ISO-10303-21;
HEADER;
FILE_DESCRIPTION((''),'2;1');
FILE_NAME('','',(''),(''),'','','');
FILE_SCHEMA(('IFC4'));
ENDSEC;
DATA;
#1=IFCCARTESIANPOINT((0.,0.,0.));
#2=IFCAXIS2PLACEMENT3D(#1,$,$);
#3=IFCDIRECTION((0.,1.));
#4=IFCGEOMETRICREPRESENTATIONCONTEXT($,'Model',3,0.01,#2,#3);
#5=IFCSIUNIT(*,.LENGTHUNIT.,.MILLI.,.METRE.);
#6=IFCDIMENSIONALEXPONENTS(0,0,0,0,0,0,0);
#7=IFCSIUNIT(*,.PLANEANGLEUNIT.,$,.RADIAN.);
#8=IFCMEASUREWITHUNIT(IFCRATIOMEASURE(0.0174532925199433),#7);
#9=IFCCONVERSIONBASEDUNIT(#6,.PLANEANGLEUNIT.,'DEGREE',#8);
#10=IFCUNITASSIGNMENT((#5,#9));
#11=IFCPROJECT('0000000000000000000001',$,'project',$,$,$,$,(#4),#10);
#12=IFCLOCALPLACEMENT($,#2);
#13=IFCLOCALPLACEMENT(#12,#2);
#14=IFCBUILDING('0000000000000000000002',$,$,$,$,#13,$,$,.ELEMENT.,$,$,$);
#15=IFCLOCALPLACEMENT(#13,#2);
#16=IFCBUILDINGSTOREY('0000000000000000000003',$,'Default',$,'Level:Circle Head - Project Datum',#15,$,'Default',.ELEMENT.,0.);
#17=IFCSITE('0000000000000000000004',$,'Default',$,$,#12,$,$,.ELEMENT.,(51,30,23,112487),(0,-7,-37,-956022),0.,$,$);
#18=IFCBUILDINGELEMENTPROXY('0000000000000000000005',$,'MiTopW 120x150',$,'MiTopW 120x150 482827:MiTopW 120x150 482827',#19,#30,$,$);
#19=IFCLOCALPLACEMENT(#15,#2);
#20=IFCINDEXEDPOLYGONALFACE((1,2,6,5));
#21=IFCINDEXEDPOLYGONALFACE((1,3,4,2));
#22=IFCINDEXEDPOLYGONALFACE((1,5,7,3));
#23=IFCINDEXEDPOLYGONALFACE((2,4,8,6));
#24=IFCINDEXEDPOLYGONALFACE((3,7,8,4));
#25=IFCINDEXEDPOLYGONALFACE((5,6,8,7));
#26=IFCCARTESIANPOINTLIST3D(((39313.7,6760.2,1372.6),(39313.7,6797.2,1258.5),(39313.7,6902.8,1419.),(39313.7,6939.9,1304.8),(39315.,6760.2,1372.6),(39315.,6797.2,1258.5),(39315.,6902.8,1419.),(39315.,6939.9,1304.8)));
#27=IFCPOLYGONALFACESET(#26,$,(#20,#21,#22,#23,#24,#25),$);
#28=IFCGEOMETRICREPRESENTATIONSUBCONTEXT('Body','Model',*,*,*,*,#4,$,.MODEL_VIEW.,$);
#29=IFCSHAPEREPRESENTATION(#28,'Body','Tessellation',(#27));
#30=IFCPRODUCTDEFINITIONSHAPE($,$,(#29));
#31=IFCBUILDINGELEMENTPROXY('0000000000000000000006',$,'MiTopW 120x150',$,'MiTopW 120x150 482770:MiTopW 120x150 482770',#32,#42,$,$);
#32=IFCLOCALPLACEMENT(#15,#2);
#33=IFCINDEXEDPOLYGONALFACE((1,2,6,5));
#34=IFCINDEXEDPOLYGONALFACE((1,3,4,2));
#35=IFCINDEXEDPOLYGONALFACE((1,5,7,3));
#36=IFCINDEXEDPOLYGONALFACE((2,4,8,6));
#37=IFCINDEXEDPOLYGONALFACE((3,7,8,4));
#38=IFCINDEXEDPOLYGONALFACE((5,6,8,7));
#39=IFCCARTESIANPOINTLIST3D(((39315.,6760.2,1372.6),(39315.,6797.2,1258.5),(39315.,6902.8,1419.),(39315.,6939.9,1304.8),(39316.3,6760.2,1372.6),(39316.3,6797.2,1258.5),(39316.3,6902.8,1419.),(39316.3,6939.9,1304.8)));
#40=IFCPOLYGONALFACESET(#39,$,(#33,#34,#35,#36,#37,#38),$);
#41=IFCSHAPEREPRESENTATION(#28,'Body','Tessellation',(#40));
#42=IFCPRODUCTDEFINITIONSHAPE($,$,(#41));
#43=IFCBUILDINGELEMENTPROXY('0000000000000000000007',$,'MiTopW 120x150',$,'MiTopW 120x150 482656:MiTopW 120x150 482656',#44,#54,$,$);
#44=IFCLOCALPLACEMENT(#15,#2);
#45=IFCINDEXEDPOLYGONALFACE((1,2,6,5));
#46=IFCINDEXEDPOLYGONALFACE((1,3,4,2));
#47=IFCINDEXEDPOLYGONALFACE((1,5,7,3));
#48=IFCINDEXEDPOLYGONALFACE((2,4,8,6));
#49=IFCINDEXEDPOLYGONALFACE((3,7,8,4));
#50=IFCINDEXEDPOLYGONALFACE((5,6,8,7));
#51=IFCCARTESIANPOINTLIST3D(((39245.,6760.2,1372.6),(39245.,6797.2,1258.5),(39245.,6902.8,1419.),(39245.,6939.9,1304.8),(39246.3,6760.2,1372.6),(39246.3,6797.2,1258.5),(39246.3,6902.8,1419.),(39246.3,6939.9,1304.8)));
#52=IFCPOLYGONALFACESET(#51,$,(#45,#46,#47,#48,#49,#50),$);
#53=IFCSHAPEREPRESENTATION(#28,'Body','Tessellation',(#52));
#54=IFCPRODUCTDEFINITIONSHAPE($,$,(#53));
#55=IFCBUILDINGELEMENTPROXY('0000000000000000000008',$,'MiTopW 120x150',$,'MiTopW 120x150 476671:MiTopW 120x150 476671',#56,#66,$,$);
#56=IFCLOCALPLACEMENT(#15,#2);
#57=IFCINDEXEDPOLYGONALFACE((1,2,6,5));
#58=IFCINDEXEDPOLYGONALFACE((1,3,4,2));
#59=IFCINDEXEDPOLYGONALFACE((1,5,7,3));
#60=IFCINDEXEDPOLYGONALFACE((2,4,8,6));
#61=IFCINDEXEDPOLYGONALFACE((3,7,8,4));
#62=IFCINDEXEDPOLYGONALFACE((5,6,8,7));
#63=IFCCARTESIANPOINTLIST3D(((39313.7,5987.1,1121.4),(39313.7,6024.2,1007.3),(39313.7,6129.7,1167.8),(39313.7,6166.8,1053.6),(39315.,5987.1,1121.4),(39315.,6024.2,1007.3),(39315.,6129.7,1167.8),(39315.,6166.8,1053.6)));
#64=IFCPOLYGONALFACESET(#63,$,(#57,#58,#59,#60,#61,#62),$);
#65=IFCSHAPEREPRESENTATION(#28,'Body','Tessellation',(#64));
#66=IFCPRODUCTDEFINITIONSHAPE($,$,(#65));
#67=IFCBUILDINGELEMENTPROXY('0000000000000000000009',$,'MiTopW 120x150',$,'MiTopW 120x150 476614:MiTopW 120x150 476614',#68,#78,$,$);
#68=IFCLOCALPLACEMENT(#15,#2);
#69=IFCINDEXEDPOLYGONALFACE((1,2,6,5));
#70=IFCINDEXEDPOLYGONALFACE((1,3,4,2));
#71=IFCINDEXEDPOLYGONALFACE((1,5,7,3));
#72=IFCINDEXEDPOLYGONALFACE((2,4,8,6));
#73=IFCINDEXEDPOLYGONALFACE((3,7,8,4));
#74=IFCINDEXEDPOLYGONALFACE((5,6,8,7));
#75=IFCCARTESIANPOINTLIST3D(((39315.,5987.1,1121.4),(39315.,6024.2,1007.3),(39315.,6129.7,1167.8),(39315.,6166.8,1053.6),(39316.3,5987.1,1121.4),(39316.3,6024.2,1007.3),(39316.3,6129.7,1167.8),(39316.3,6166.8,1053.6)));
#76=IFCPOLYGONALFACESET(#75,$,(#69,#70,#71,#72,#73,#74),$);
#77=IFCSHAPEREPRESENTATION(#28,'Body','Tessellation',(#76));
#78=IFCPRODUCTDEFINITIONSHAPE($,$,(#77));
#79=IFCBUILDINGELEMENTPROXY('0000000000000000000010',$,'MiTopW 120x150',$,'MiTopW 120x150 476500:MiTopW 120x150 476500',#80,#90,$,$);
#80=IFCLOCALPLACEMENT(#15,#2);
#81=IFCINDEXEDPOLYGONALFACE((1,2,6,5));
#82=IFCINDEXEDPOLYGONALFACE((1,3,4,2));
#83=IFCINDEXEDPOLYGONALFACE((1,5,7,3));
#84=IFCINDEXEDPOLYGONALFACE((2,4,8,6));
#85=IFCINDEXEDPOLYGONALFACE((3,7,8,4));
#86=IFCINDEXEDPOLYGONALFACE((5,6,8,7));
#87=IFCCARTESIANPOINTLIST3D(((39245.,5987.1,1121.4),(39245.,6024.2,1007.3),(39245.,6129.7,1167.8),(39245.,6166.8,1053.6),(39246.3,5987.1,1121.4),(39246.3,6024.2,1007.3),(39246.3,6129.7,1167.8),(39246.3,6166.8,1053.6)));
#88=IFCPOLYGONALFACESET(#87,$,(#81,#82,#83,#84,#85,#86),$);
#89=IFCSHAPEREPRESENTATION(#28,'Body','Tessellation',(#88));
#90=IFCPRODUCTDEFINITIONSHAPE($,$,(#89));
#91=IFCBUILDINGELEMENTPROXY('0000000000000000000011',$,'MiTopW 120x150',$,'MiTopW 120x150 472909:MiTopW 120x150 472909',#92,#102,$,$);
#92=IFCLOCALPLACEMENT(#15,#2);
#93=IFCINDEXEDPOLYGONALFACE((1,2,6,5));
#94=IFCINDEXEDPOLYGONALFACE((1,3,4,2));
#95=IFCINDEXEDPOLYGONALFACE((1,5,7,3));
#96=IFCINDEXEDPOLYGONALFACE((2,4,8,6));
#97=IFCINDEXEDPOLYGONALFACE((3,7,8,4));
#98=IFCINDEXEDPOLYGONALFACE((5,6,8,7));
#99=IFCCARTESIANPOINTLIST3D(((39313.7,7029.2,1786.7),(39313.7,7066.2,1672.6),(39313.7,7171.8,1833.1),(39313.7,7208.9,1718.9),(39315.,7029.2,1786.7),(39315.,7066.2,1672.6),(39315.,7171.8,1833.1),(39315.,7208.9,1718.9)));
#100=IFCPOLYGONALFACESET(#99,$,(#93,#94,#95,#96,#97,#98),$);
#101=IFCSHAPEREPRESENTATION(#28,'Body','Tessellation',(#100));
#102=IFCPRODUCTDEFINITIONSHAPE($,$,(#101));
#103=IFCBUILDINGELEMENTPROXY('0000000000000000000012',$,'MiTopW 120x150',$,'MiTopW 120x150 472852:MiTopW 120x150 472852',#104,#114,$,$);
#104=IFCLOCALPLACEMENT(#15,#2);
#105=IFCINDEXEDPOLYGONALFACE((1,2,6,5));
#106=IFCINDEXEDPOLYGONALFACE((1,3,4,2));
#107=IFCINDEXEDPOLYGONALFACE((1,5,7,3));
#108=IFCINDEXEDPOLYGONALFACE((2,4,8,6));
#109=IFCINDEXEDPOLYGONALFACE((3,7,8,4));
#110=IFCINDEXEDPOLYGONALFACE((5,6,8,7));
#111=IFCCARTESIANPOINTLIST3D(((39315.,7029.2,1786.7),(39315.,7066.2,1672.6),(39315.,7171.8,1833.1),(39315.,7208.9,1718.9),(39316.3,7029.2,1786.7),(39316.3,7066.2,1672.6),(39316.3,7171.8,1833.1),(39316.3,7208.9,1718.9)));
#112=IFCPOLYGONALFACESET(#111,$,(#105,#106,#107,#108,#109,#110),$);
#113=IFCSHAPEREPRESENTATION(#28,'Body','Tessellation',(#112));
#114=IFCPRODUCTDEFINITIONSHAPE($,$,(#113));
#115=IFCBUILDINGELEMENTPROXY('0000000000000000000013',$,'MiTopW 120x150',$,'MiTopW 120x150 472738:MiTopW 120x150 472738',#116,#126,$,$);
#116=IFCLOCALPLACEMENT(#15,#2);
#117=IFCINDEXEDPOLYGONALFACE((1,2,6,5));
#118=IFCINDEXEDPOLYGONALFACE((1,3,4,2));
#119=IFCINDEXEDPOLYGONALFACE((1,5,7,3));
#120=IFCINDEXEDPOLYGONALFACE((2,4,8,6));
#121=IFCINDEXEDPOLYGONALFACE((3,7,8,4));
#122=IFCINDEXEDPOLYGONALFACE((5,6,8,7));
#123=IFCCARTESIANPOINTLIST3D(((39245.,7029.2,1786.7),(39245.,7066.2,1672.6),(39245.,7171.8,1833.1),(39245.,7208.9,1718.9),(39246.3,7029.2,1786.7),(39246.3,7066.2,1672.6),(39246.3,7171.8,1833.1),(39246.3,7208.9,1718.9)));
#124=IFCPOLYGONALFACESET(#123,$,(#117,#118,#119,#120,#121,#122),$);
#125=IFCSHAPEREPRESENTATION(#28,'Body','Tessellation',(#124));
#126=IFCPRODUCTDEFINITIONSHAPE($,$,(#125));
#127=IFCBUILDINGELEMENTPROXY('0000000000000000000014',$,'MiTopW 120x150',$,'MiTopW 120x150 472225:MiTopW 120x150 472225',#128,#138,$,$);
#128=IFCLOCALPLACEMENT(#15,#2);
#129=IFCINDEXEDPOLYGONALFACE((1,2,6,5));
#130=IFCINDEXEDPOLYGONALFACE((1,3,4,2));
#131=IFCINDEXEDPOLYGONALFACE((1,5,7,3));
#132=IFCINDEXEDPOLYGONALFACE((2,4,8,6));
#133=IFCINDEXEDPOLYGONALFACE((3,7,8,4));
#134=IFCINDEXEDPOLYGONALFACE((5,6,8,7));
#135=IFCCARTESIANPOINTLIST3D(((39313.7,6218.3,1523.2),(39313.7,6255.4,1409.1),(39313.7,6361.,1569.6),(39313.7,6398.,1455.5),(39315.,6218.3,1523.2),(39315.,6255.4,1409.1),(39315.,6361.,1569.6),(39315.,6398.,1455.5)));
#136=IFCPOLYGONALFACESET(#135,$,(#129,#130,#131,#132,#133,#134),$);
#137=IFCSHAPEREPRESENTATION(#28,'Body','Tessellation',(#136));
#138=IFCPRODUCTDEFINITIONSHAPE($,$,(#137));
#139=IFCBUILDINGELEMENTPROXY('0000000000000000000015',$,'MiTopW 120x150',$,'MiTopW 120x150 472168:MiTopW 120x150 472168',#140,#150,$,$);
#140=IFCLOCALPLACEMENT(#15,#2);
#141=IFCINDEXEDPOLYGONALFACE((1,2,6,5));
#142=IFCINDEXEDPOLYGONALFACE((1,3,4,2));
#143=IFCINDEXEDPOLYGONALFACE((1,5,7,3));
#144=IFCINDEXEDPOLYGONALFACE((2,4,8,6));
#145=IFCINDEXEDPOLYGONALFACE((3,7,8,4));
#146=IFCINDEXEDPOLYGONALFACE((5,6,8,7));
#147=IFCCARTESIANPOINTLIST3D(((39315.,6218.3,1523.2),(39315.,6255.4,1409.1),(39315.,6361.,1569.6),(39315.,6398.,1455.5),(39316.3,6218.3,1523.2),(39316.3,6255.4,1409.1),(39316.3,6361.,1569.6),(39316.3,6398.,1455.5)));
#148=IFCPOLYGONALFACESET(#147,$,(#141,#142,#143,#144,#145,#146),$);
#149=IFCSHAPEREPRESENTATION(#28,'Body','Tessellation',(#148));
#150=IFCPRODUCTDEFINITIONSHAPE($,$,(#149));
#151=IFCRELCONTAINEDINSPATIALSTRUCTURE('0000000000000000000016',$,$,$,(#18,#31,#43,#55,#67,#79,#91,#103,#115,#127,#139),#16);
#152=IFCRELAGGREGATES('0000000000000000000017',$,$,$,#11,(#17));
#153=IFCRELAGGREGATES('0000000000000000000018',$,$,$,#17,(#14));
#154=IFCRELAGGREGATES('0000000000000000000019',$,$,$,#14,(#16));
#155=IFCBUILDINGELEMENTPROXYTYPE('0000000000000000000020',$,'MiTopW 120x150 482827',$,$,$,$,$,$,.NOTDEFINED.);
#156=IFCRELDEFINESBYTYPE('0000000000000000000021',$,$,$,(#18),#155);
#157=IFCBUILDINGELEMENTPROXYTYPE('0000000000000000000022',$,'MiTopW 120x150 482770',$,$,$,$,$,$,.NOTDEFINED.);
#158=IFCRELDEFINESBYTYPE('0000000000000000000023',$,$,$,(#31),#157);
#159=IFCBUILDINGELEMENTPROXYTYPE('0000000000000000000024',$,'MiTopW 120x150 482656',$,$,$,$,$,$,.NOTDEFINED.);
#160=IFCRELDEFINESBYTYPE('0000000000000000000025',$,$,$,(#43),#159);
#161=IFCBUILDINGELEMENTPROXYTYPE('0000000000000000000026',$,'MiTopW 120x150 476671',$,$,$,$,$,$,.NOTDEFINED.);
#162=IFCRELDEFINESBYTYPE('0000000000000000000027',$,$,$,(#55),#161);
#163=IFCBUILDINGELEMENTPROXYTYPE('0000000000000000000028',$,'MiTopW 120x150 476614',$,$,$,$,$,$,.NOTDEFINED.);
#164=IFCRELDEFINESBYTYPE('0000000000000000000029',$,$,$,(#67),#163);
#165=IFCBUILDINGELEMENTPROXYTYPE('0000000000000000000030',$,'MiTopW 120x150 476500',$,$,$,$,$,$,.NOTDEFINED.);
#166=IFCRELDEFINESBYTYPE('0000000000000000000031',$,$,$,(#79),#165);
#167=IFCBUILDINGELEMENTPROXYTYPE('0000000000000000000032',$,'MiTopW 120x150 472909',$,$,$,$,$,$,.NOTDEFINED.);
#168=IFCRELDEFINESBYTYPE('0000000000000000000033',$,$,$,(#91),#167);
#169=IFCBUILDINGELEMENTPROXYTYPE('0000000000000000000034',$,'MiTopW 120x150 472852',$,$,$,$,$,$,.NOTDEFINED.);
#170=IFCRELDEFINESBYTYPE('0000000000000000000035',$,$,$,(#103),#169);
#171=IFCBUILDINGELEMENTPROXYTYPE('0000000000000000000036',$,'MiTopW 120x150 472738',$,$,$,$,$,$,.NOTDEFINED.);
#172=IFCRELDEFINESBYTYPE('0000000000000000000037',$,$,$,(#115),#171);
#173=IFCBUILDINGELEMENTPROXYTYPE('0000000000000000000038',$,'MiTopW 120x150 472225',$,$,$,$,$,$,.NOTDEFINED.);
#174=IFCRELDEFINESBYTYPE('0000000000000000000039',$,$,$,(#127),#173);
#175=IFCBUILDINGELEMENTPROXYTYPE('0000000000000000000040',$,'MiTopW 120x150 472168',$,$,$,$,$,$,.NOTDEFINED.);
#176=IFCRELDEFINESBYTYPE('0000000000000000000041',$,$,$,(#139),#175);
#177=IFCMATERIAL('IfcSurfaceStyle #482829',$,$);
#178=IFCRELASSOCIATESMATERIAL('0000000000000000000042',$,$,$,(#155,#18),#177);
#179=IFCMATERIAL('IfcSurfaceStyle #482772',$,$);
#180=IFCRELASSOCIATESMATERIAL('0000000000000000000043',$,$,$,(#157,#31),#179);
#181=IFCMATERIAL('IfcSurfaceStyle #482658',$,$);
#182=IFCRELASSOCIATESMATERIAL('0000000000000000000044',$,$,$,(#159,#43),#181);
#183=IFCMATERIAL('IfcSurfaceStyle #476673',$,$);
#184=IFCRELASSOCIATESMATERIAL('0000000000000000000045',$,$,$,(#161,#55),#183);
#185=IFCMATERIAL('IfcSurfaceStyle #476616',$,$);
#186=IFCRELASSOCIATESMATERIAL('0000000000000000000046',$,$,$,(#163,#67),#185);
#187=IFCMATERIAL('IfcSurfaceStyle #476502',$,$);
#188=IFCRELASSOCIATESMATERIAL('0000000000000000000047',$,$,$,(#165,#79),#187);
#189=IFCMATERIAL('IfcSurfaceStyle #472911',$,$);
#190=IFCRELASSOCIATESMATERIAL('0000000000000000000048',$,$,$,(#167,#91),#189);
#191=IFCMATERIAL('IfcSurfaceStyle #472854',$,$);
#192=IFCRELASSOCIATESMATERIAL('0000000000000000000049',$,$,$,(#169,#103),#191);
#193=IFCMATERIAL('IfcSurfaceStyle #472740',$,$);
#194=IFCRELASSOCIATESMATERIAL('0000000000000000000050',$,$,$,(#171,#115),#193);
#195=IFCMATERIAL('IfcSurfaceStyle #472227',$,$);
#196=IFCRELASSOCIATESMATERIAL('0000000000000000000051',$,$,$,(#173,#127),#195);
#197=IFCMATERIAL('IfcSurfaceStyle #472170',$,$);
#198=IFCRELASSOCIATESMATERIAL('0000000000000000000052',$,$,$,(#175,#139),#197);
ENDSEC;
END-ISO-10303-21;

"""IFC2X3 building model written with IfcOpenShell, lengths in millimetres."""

from ifc_helpers import new_model, entity, si_unit, converted_unit, direction, frame, origin, place, context, subcontext, project, spatial, polyline, outline, extrude, source, transform, mapped, material, type_object, type_shapes, element, save


model = new_model("IFC2X3")

# Units and contexts
model_context = context("Model", 3, precision=0.01, world=origin(), true_north=direction((0.0, 1.0)))
body_context = subcontext(model_context, "Body", "Model", "MODEL_VIEW")
ifc_project = project(units=[si_unit("LENGTHUNIT", "METRE", prefix="MILLI"), converted_unit("PLANEANGLEUNIT", "DEGREE", entity("IfcRatioMeasure", 0.0174532925199433), si_unit("PLANEANGLEUNIT", "RADIAN"), dimensions=[0, 0, 0, 0, 0, 0, 0])], contexts=[model_context])

# Site, building, storey
site_placement = place(None, origin())
site = spatial("IfcSite", under=ifc_project, at=site_placement, Name="Default", CompositionType="ELEMENT", RefLatitude=(51, 30, 23, 112487), RefLongitude=(0, -7, -37, -956022), RefElevation=0.0)
building_placement = place(site_placement, origin())
building = spatial("IfcBuilding", under=site, at=building_placement, CompositionType="ELEMENT")
storey_placement = place(building_placement, origin())
storey = spatial("IfcBuildingStorey", under=building, at=storey_placement, Name="Default", ObjectType="Level:Circle Head - Project Datum", LongName="Default", CompositionType="ELEMENT", Elevation=0.0)

# Building element proxies
ifc_material_1 = material(Name="IfcSurfaceStyle #482829")
building_element_proxy_type_1 = type_object("IfcBuildingElementProxyType", Name="MiTopW 120x150 482827", PredefinedType="NOTDEFINED", material=ifc_material_1)
shared_shape_1 = source(origin(), body_context, "Body", "SweptSolid", [
    extrude(outline(polyline([(-75.0, -60.0), (75.0, -60.0), (75.0, 60.0), (-75.0, 60.0), (-75.0, -60.0)])), frame((75.0, 60.0, 0.0), z_axis=(0.0, 0.0, 1.0), x_axis=(-1.0, 0.0, 0.0)), (0.0, 0.0, 1.0), 1.3),
])
type_shapes(building_element_proxy_type_1, [shared_shape_1])
proxy_1_placement = place(building_placement, frame((39315.0, 6760.2, 1372.6), z_axis=(-1.0, 0.0, 0.0), x_axis=(0.0, 0.951057, 0.309017)))
element("IfcBuildingElementProxy", 1, at=proxy_1_placement, inside=storey, type_object=building_element_proxy_type_1, material=ifc_material_1, Name="MiTopW 120x150", ObjectType="MiTopW 120x150 482827:MiTopW 120x150 482827", context=body_context, shape_type="MappedRepresentation", body=[
    mapped(shared_shape_1, transform((0.0, 0.0, 0.0), scale=1.0)),
])
ifc_material_2 = material(Name="IfcSurfaceStyle #482772")
building_element_proxy_type_2 = type_object("IfcBuildingElementProxyType", Name="MiTopW 120x150 482770", PredefinedType="NOTDEFINED", material=ifc_material_2)
shared_shape_2 = source(origin(), body_context, "Body", "SweptSolid", [
    extrude(outline(polyline([(-75.0, -60.0), (75.0, -60.0), (75.0, 60.0), (-75.0, 60.0), (-75.0, -60.0)])), frame((75.0, 60.0, 0.0), z_axis=(0.0, 0.0, 1.0), x_axis=(-1.0, 0.0, 0.0)), (0.0, 0.0, 1.0), 1.3),
])
type_shapes(building_element_proxy_type_2, [shared_shape_2])
proxy_2_placement = place(building_placement, frame((39316.3, 6760.2, 1372.6), z_axis=(-1.0, 0.0, 0.0), x_axis=(0.0, 0.951057, 0.309017)))
element("IfcBuildingElementProxy", 2, at=proxy_2_placement, inside=storey, type_object=building_element_proxy_type_2, material=ifc_material_2, Name="MiTopW 120x150", ObjectType="MiTopW 120x150 482770:MiTopW 120x150 482770", context=body_context, shape_type="MappedRepresentation", body=[
    mapped(shared_shape_2, transform((0.0, 0.0, 0.0), scale=1.0)),
])
ifc_material_3 = material(Name="IfcSurfaceStyle #482658")
building_element_proxy_type_3 = type_object("IfcBuildingElementProxyType", Name="MiTopW 120x150 482656", PredefinedType="NOTDEFINED", material=ifc_material_3)
shared_shape_3 = source(origin(), body_context, "Body", "SweptSolid", [
    extrude(outline(polyline([(-75.0, -60.0), (75.0, -60.0), (75.0, 60.0), (-75.0, 60.0), (-75.0, -60.0)])), frame((75.0, 60.0, 0.0), z_axis=(0.0, 0.0, 1.0), x_axis=(-1.0, 0.0, 0.0)), (0.0, 0.0, 1.0), 1.3),
])
type_shapes(building_element_proxy_type_3, [shared_shape_3])
proxy_3_placement = place(building_placement, frame((39246.3, 6760.2, 1372.6), z_axis=(-1.0, 0.0, 0.0), x_axis=(0.0, 0.951057, 0.309017)))
element("IfcBuildingElementProxy", 3, at=proxy_3_placement, inside=storey, type_object=building_element_proxy_type_3, material=ifc_material_3, Name="MiTopW 120x150", ObjectType="MiTopW 120x150 482656:MiTopW 120x150 482656", context=body_context, shape_type="MappedRepresentation", body=[
    mapped(shared_shape_3, transform((0.0, 0.0, 0.0), scale=1.0)),
])
ifc_material_4 = material(Name="IfcSurfaceStyle #476673")
building_element_proxy_type_4 = type_object("IfcBuildingElementProxyType", Name="MiTopW 120x150 476671", PredefinedType="NOTDEFINED", material=ifc_material_4)
shared_shape_4 = source(origin(), body_context, "Body", "SweptSolid", [
    extrude(outline(polyline([(-75.0, -60.0), (75.0, -60.0), (75.0, 60.0), (-75.0, 60.0), (-75.0, -60.0)])), frame((75.0, 60.0, 0.0), z_axis=(0.0, 0.0, 1.0), x_axis=(-1.0, 0.0, 0.0)), (0.0, 0.0, 1.0), 1.3),
])
type_shapes(building_element_proxy_type_4, [shared_shape_4])
proxy_4_placement = place(building_placement, frame((39315.0, 5987.1, 1121.4), z_axis=(-1.0, 0.0, 0.0), x_axis=(0.0, 0.951057, 0.309017)))
element("IfcBuildingElementProxy", 4, at=proxy_4_placement, inside=storey, type_object=building_element_proxy_type_4, material=ifc_material_4, Name="MiTopW 120x150", ObjectType="MiTopW 120x150 476671:MiTopW 120x150 476671", context=body_context, shape_type="MappedRepresentation", body=[
    mapped(shared_shape_4, transform((0.0, 0.0, 0.0), scale=1.0)),
])
ifc_material_5 = material(Name="IfcSurfaceStyle #476616")
building_element_proxy_type_5 = type_object("IfcBuildingElementProxyType", Name="MiTopW 120x150 476614", PredefinedType="NOTDEFINED", material=ifc_material_5)
shared_shape_5 = source(origin(), body_context, "Body", "SweptSolid", [
    extrude(outline(polyline([(-75.0, -60.0), (75.0, -60.0), (75.0, 60.0), (-75.0, 60.0), (-75.0, -60.0)])), frame((75.0, 60.0, 0.0), z_axis=(0.0, 0.0, 1.0), x_axis=(-1.0, 0.0, 0.0)), (0.0, 0.0, 1.0), 1.3),
])
type_shapes(building_element_proxy_type_5, [shared_shape_5])
proxy_5_placement = place(building_placement, frame((39316.3, 5987.1, 1121.4), z_axis=(-1.0, 0.0, 0.0), x_axis=(0.0, 0.951057, 0.309017)))
element("IfcBuildingElementProxy", 5, at=proxy_5_placement, inside=storey, type_object=building_element_proxy_type_5, material=ifc_material_5, Name="MiTopW 120x150", ObjectType="MiTopW 120x150 476614:MiTopW 120x150 476614", context=body_context, shape_type="MappedRepresentation", body=[
    mapped(shared_shape_5, transform((0.0, 0.0, 0.0), scale=1.0)),
])
ifc_material_6 = material(Name="IfcSurfaceStyle #476502")
building_element_proxy_type_6 = type_object("IfcBuildingElementProxyType", Name="MiTopW 120x150 476500", PredefinedType="NOTDEFINED", material=ifc_material_6)
shared_shape_6 = source(origin(), body_context, "Body", "SweptSolid", [
    extrude(outline(polyline([(-75.0, -60.0), (75.0, -60.0), (75.0, 60.0), (-75.0, 60.0), (-75.0, -60.0)])), frame((75.0, 60.0, 0.0), z_axis=(0.0, 0.0, 1.0), x_axis=(-1.0, 0.0, 0.0)), (0.0, 0.0, 1.0), 1.3),
])
type_shapes(building_element_proxy_type_6, [shared_shape_6])
proxy_6_placement = place(building_placement, frame((39246.3, 5987.1, 1121.4), z_axis=(-1.0, 0.0, 0.0), x_axis=(0.0, 0.951057, 0.309017)))
element("IfcBuildingElementProxy", 6, at=proxy_6_placement, inside=storey, type_object=building_element_proxy_type_6, material=ifc_material_6, Name="MiTopW 120x150", ObjectType="MiTopW 120x150 476500:MiTopW 120x150 476500", context=body_context, shape_type="MappedRepresentation", body=[
    mapped(shared_shape_6, transform((0.0, 0.0, 0.0), scale=1.0)),
])
ifc_material_7 = material(Name="IfcSurfaceStyle #472911")
building_element_proxy_type_7 = type_object("IfcBuildingElementProxyType", Name="MiTopW 120x150 472909", PredefinedType="NOTDEFINED", material=ifc_material_7)
shared_shape_7 = source(origin(), body_context, "Body", "SweptSolid", [
    extrude(outline(polyline([(-75.0, -60.0), (75.0, -60.0), (75.0, 60.0), (-75.0, 60.0), (-75.0, -60.0)])), frame((75.0, 60.0, 0.0), z_axis=(0.0, 0.0, 1.0), x_axis=(-1.0, 0.0, 0.0)), (0.0, 0.0, 1.0), 1.3),
])
type_shapes(building_element_proxy_type_7, [shared_shape_7])
proxy_7_placement = place(building_placement, frame((39315.0, 7029.2, 1786.7), z_axis=(-1.0, 0.0, 0.0), x_axis=(0.0, 0.951057, 0.309017)))
element("IfcBuildingElementProxy", 7, at=proxy_7_placement, inside=storey, type_object=building_element_proxy_type_7, material=ifc_material_7, Name="MiTopW 120x150", ObjectType="MiTopW 120x150 472909:MiTopW 120x150 472909", context=body_context, shape_type="MappedRepresentation", body=[
    mapped(shared_shape_7, transform((0.0, 0.0, 0.0), scale=1.0)),
])
ifc_material_8 = material(Name="IfcSurfaceStyle #472854")
building_element_proxy_type_8 = type_object("IfcBuildingElementProxyType", Name="MiTopW 120x150 472852", PredefinedType="NOTDEFINED", material=ifc_material_8)
shared_shape_8 = source(origin(), body_context, "Body", "SweptSolid", [
    extrude(outline(polyline([(-75.0, -60.0), (75.0, -60.0), (75.0, 60.0), (-75.0, 60.0), (-75.0, -60.0)])), frame((75.0, 60.0, 0.0), z_axis=(0.0, 0.0, 1.0), x_axis=(-1.0, 0.0, 0.0)), (0.0, 0.0, 1.0), 1.3),
])
type_shapes(building_element_proxy_type_8, [shared_shape_8])
proxy_8_placement = place(building_placement, frame((39316.3, 7029.2, 1786.7), z_axis=(-1.0, 0.0, 0.0), x_axis=(0.0, 0.951057, 0.309017)))
element("IfcBuildingElementProxy", 8, at=proxy_8_placement, inside=storey, type_object=building_element_proxy_type_8, material=ifc_material_8, Name="MiTopW 120x150", ObjectType="MiTopW 120x150 472852:MiTopW 120x150 472852", context=body_context, shape_type="MappedRepresentation", body=[
    mapped(shared_shape_8, transform((0.0, 0.0, 0.0), scale=1.0)),
])
ifc_material_9 = material(Name="IfcSurfaceStyle #472740")
building_element_proxy_type_9 = type_object("IfcBuildingElementProxyType", Name="MiTopW 120x150 472738", PredefinedType="NOTDEFINED", material=ifc_material_9)
shared_shape_9 = source(origin(), body_context, "Body", "SweptSolid", [
    extrude(outline(polyline([(-75.0, -60.0), (75.0, -60.0), (75.0, 60.0), (-75.0, 60.0), (-75.0, -60.0)])), frame((75.0, 60.0, 0.0), z_axis=(0.0, 0.0, 1.0), x_axis=(-1.0, 0.0, 0.0)), (0.0, 0.0, 1.0), 1.3),
])
type_shapes(building_element_proxy_type_9, [shared_shape_9])
proxy_9_placement = place(building_placement, frame((39246.3, 7029.2, 1786.7), z_axis=(-1.0, 0.0, 0.0), x_axis=(0.0, 0.951057, 0.309017)))
element("IfcBuildingElementProxy", 9, at=proxy_9_placement, inside=storey, type_object=building_element_proxy_type_9, material=ifc_material_9, Name="MiTopW 120x150", ObjectType="MiTopW 120x150 472738:MiTopW 120x150 472738", context=body_context, shape_type="MappedRepresentation", body=[
    mapped(shared_shape_9, transform((0.0, 0.0, 0.0), scale=1.0)),
])
ifc_material_10 = material(Name="IfcSurfaceStyle #472227")
building_element_proxy_type_10 = type_object("IfcBuildingElementProxyType", Name="MiTopW 120x150 472225", PredefinedType="NOTDEFINED", material=ifc_material_10)
shared_shape_10 = source(origin(), body_context, "Body", "SweptSolid", [
    extrude(outline(polyline([(-75.0, -60.0), (75.0, -60.0), (75.0, 60.0), (-75.0, 60.0), (-75.0, -60.0)])), frame((75.0, 60.0, 0.0), z_axis=(0.0, 0.0, 1.0), x_axis=(-1.0, 0.0, 0.0)), (0.0, 0.0, 1.0), 1.3),
])
type_shapes(building_element_proxy_type_10, [shared_shape_10])
proxy_10_placement = place(building_placement, frame((39315.0, 6218.3, 1523.2), z_axis=(-1.0, 0.0, 0.0), x_axis=(0.0, 0.951057, 0.309017)))
element("IfcBuildingElementProxy", 10, at=proxy_10_placement, inside=storey, type_object=building_element_proxy_type_10, material=ifc_material_10, Name="MiTopW 120x150", ObjectType="MiTopW 120x150 472225:MiTopW 120x150 472225", context=body_context, shape_type="MappedRepresentation", body=[
    mapped(shared_shape_10, transform((0.0, 0.0, 0.0), scale=1.0)),
])
ifc_material_11 = material(Name="IfcSurfaceStyle #472170")
building_element_proxy_type_11 = type_object("IfcBuildingElementProxyType", Name="MiTopW 120x150 472168", PredefinedType="NOTDEFINED", material=ifc_material_11)
shared_shape_11 = source(origin(), body_context, "Body", "SweptSolid", [
    extrude(outline(polyline([(-75.0, -60.0), (75.0, -60.0), (75.0, 60.0), (-75.0, 60.0), (-75.0, -60.0)])), frame((75.0, 60.0, 0.0), z_axis=(0.0, 0.0, 1.0), x_axis=(-1.0, 0.0, 0.0)), (0.0, 0.0, 1.0), 1.3),
])
type_shapes(building_element_proxy_type_11, [shared_shape_11])
proxy_11_placement = place(building_placement, frame((39316.3, 6218.3, 1523.2), z_axis=(-1.0, 0.0, 0.0), x_axis=(0.0, 0.951057, 0.309017)))
element("IfcBuildingElementProxy", 11, at=proxy_11_placement, inside=storey, type_object=building_element_proxy_type_11, material=ifc_material_11, Name="MiTopW 120x150", ObjectType="MiTopW 120x150 472168:MiTopW 120x150 472168", context=body_context, shape_type="MappedRepresentation", body=[
    mapped(shared_shape_11, transform((0.0, 0.0, 0.0), scale=1.0)),
])

save(model, "model.ifc")
